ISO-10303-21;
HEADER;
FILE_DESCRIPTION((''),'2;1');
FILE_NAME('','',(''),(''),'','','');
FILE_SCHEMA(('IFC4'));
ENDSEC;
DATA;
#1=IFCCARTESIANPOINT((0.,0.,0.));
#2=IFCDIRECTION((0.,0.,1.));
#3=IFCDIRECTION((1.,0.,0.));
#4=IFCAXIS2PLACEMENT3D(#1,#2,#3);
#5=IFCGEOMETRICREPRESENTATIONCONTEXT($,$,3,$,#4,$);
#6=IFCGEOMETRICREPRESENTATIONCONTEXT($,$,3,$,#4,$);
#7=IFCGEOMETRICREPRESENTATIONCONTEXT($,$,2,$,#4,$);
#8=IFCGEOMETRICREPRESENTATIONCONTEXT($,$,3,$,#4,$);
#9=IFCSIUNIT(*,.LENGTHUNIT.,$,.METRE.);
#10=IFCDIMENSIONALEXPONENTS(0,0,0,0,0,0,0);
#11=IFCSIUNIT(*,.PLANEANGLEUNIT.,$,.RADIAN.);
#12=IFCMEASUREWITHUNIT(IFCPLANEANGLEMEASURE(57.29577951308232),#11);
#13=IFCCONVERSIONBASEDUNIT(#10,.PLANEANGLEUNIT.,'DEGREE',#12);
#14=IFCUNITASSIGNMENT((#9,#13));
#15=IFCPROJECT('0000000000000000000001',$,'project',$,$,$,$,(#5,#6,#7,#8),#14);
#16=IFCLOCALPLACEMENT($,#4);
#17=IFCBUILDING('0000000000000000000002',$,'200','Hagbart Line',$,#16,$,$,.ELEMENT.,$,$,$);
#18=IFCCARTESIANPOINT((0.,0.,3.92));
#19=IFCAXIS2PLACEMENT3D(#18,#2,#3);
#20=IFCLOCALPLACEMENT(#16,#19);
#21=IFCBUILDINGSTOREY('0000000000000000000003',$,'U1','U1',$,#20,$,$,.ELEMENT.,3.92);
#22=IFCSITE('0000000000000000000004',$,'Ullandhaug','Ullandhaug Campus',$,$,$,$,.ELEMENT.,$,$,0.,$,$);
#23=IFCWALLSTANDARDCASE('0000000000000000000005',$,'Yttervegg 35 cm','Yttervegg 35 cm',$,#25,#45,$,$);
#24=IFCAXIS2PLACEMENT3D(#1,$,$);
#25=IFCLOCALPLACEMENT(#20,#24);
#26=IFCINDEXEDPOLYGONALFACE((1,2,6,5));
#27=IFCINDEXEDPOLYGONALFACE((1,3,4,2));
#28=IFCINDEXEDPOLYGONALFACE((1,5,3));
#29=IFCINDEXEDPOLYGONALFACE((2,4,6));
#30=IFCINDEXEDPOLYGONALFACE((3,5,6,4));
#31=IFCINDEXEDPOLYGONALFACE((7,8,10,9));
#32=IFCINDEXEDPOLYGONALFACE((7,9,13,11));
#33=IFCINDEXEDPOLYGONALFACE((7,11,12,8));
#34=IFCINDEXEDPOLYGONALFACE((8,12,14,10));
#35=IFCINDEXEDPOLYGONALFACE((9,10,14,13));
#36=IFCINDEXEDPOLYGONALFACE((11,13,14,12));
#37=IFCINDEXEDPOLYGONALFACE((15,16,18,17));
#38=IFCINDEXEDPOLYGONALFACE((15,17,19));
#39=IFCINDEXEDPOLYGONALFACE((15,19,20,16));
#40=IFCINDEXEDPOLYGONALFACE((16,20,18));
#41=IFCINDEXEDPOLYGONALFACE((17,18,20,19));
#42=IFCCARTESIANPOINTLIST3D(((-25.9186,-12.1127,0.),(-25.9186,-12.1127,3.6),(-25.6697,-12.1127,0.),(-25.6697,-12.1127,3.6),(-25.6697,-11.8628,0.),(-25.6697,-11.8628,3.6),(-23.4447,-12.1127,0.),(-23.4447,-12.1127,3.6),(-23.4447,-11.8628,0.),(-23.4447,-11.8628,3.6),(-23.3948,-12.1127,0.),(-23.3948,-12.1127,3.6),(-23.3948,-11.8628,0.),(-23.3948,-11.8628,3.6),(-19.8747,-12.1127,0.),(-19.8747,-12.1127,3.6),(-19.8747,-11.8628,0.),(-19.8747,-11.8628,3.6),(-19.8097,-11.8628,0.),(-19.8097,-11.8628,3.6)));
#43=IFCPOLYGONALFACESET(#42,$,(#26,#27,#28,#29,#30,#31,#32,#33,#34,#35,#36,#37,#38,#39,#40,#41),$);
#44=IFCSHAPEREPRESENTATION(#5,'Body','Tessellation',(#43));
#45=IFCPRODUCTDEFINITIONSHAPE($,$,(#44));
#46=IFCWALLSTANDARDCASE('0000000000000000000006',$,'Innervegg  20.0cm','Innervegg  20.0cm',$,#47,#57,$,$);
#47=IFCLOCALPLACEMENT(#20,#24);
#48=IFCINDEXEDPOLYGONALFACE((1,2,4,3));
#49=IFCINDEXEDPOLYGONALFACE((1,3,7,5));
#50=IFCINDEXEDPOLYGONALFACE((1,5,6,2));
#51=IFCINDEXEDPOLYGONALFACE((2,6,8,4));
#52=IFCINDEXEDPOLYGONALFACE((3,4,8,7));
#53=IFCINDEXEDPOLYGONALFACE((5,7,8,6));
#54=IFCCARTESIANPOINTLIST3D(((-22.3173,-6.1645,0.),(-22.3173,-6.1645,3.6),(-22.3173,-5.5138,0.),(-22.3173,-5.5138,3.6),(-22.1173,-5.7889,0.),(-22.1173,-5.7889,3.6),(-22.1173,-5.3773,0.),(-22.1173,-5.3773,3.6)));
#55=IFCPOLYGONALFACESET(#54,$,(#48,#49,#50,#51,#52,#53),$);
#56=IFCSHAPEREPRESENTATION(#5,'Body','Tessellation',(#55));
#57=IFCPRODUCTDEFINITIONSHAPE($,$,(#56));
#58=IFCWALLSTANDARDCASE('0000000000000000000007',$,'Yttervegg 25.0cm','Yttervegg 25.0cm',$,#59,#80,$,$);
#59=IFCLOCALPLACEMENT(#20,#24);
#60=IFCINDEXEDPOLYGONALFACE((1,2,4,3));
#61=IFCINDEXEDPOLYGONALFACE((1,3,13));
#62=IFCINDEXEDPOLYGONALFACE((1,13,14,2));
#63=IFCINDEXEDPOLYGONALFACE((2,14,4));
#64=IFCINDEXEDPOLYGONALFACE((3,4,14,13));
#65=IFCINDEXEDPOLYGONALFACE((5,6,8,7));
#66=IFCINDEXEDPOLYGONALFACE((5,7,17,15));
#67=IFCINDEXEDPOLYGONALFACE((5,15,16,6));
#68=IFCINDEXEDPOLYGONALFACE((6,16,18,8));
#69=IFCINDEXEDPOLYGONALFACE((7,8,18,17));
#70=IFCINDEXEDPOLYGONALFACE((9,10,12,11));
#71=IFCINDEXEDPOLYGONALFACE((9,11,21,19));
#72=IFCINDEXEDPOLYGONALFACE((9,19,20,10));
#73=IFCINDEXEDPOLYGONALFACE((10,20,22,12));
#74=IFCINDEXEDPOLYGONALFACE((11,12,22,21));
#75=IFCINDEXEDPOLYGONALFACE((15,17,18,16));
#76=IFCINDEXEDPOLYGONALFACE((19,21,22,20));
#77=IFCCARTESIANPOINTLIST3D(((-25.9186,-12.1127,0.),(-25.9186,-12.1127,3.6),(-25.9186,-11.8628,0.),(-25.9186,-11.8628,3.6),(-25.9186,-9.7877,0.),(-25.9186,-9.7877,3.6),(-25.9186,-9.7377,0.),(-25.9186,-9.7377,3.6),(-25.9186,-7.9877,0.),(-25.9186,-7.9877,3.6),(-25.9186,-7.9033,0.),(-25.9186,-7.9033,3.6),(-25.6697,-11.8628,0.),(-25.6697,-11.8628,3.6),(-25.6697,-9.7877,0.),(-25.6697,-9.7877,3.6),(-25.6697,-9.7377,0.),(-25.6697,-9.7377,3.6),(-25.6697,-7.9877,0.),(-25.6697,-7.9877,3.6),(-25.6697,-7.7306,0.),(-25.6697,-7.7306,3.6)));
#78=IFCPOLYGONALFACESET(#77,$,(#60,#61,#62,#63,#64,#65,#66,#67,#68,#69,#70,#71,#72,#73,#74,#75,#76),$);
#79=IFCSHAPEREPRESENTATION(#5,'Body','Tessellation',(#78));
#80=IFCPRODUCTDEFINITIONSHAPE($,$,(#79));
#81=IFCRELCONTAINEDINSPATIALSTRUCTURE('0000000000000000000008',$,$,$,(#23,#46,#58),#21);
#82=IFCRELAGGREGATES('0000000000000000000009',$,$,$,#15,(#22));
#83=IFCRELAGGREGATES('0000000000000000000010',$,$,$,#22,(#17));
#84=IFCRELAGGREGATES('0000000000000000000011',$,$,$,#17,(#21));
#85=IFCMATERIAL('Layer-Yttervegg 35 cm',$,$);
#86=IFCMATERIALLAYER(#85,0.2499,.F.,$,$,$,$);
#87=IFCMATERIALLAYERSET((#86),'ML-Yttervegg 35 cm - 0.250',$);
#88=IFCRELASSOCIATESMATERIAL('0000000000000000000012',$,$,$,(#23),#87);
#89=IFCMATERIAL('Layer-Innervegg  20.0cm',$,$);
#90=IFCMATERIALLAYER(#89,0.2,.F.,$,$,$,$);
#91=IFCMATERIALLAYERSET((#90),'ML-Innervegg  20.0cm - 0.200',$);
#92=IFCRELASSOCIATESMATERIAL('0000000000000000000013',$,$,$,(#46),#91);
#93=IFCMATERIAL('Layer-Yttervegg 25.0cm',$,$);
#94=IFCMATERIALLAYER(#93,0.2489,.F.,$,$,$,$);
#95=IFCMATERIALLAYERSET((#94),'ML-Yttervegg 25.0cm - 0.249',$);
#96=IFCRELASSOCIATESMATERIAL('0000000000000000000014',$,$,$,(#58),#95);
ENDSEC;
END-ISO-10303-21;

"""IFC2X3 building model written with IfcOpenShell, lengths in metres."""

from ifc_helpers import new_model, entity, si_unit, converted_unit, frame, origin_with_axes, place, context, project, spatial, polyline, outline, extrude, material, layer, layer_set, layer_usage, element, save


model = new_model("IFC2X3")

# Units and contexts
context_of_model_1 = context(None, 3, world=origin_with_axes())
context_of_model_2 = context(None, 3, world=origin_with_axes())
context_of_model_3 = context(None, 2, world=origin_with_axes())
context_of_model_4 = context(None, 3, world=origin_with_axes())
ifc_project = project(units=[si_unit("LENGTHUNIT", "METRE"), converted_unit("PLANEANGLEUNIT", "DEGREE", entity("IfcPlaneAngleMeasure", 57.29577951308232), si_unit("PLANEANGLEUNIT", "RADIAN"), dimensions=[0, 0, 0, 0, 0, 0, 0])], contexts=[context_of_model_1, context_of_model_2, context_of_model_3, context_of_model_4])

# Site, building, storey
site = spatial("IfcSite", under=ifc_project, Name="Ullandhaug", Description="Ullandhaug Campus", CompositionType="ELEMENT", RefElevation=0.0)
building_placement = place(None, origin_with_axes())
building = spatial("IfcBuilding", under=site, at=building_placement, Name="200", Description="Hagbart Line", CompositionType="ELEMENT")
storey_placement = place(building_placement, frame((0.0, 0.0, 3.92), z_axis=(0.0, 0.0, 1.0), x_axis=(1.0, 0.0, 0.0)))
storey = spatial("IfcBuildingStorey", under=building, at=storey_placement, Name="U1", Description="U1", CompositionType="ELEMENT", Elevation=3.92)

# Shared definitions
ifc_material_1 = material(Name="Layer-Innervegg  20.0cm")
ifc_layer_1 = layer(ifc_material_1, 0.2, ventilated=False)
ifc_layer_set_1 = layer_set([ifc_layer_1], Name="ML-Innervegg  20.0cm - 0.200")
ifc_layer_usage_1 = layer_usage(ifc_layer_set_1, "AXIS2", "POSITIVE", 0.0)

# Wall, openings
ifc_material_2 = material(Name="Layer-Yttervegg 35 cm")
ifc_layer_2 = layer(ifc_material_2, 0.2499, ventilated=False)
ifc_layer_set_2 = layer_set([ifc_layer_2], Name="ML-Yttervegg 35 cm - 0.250")
ifc_layer_usage_2 = layer_usage(ifc_layer_set_2, "AXIS2", "POSITIVE", 0.0)
wall_1_placement = place(storey_placement, frame((-25.9186, -12.1127, 0.0), z_axis=(0.0, 0.0, 1.0), x_axis=(1.0, 0.0, 0.0)))
wall_1 = element("IfcWallStandardCase", 1, at=wall_1_placement, inside=storey, material=ifc_layer_usage_2, Name="Yttervegg 35 cm", Description="Yttervegg 35 cm", context=context_of_model_1, shape_type="SweptSolid", body=[
    extrude(outline(polyline([(0.0, 0.0), (6.0439, 0.0), (6.1089, 0.2499), (0.2489, 0.2499), (0.0, 0.0)])), origin_with_axes(), (0.0, 0.0, 1.0), 3.6),
])
opening_1_placement = place(wall_1_placement, frame((0.2489, 0.2499, 0.0), z_axis=(0.0, 0.0, 1.0), x_axis=(1.0, 0.0, 0.0)))
element("IfcOpeningElement", 2, at=opening_1_placement, cuts=wall_1, context=context_of_model_1, shape_type="SweptSolid", body=[
    extrude(outline(polyline([(0.0, 0.0), (3.6, 0.0), (3.6, 2.2249), (0.0, 2.2249), (0.0, 0.0)])), frame((0.0, 0.0, 0.0), z_axis=(0.0, 1.0, 0.0), x_axis=(0.0, 0.0, 1.0)), (0.0, 0.0, -1.0), 0.2499),
])
opening_2_placement = place(wall_1_placement, frame((2.5238, 0.2499, 0.0), z_axis=(0.0, 0.0, 1.0), x_axis=(1.0, 0.0, 0.0)))
element("IfcOpeningElement", 3, at=opening_2_placement, cuts=wall_1, context=context_of_model_1, shape_type="SweptSolid", body=[
    extrude(outline(polyline([(0.0, 0.0), (3.6, 0.0), (3.6, 2.37), (0.0, 2.37), (0.0, 0.0)])), frame((0.0, 0.0, 0.0), z_axis=(0.0, 1.0, 0.0), x_axis=(0.0, 0.0, 1.0)), (0.0, 0.0, -1.0), 0.2499),
])
opening_3_placement = place(wall_1_placement, frame((4.8938, 0.2499, 0.0), z_axis=(0.0, 0.0, 1.0), x_axis=(1.0, 0.0, 0.0)))
element("IfcOpeningElement", 4, at=opening_3_placement, cuts=wall_1, context=context_of_model_1, shape_type="SweptSolid", body=[
    extrude(outline(polyline([(0.0, 0.0), (3.6, 0.0), (3.6, 1.15), (0.0, 1.15), (0.0, 0.0)])), frame((0.0, 0.0, 0.0), z_axis=(0.0, 1.0, 0.0), x_axis=(0.0, 0.0, 1.0)), (0.0, 0.0, -1.0), 0.2499),
])

# Wall
wall_2_placement = place(storey_placement, frame((-22.1173, -5.7889, 0.0), z_axis=(0.0, 0.0, 1.0), x_axis=(0.0, 1.0, 0.0)))
element("IfcWallStandardCase", 5, at=wall_2_placement, inside=storey, material=ifc_layer_usage_1, Name="Innervegg  20.0cm", Description="Innervegg  20.0cm", context=context_of_model_1, shape_type="SweptSolid", body=[
    extrude(outline(polyline([(0.0, 0.0), (0.4116, 0.0), (0.2751, 0.2), (-0.3756, 0.2), (0.0, 0.0)])), frame((0.0, 0.0, 0.0), z_axis=(0.0, 0.0, 1.0), x_axis=(1.0, 0.0, 0.0)), (0.0, 0.0, 1.0), 3.6),
])

# Wall, openings
ifc_material_3 = material(Name="Layer-Yttervegg 25.0cm")
ifc_layer_3 = layer(ifc_material_3, 0.2489, ventilated=False)
ifc_layer_set_3 = layer_set([ifc_layer_3], Name="ML-Yttervegg 25.0cm - 0.249")
ifc_layer_usage_3 = layer_usage(ifc_layer_set_3, "AXIS2", "POSITIVE", 0.0)
wall_3_placement = place(storey_placement, frame((-25.9186, -7.9033, 0.0), z_axis=(0.0, 0.0, 1.0), x_axis=(0.0, -1.0, 0.0)))
wall_3 = element("IfcWallStandardCase", 6, at=wall_3_placement, inside=storey, material=ifc_layer_usage_3, Name="Yttervegg 25.0cm", Description="Yttervegg 25.0cm", context=context_of_model_1, shape_type="SweptSolid", body=[
    extrude(outline(polyline([(0.0, 0.0), (4.2095, 0.0), (3.9595, 0.2489), (-0.1727, 0.2489), (0.0, 0.0)])), frame((0.0, 0.0, 0.0), z_axis=(0.0, 0.0, 1.0), x_axis=(1.0, 0.0, 0.0)), (0.0, 0.0, 1.0), 3.6),
])
opening_4_placement = place(wall_3_placement, frame((0.0845, 0.2489, 0.0), z_axis=(0.0, 0.0, 1.0), x_axis=(1.0, 0.0, 0.0)))
element("IfcOpeningElement", 7, at=opening_4_placement, cuts=wall_3, context=context_of_model_1, shape_type="SweptSolid", body=[
    extrude(outline(polyline([(0.0, 0.0), (3.6, 0.0), (3.6, 1.75), (0.0, 1.75), (0.0, 0.0)])), frame((0.0, 0.0, 0.0), z_axis=(0.0, 1.0, 0.0), x_axis=(0.0, 0.0, 1.0)), (0.0, 0.0, -1.0), 0.2489),
])
opening_5_placement = place(wall_3_placement, frame((1.8845, 0.2489, 0.0), z_axis=(0.0, 0.0, 1.0), x_axis=(1.0, 0.0, 0.0)))
element("IfcOpeningElement", 8, at=opening_5_placement, cuts=wall_3, context=context_of_model_1, shape_type="SweptSolid", body=[
    extrude(outline(polyline([(0.0, 0.0), (3.6, 0.0), (3.6, 2.0751), (0.0, 2.0751), (0.0, 0.0)])), frame((0.0, 0.0, 0.0), z_axis=(0.0, 1.0, 0.0), x_axis=(0.0, 0.0, 1.0)), (0.0, 0.0, -1.0), 0.2489),
])

save(model, "model.ifc")
